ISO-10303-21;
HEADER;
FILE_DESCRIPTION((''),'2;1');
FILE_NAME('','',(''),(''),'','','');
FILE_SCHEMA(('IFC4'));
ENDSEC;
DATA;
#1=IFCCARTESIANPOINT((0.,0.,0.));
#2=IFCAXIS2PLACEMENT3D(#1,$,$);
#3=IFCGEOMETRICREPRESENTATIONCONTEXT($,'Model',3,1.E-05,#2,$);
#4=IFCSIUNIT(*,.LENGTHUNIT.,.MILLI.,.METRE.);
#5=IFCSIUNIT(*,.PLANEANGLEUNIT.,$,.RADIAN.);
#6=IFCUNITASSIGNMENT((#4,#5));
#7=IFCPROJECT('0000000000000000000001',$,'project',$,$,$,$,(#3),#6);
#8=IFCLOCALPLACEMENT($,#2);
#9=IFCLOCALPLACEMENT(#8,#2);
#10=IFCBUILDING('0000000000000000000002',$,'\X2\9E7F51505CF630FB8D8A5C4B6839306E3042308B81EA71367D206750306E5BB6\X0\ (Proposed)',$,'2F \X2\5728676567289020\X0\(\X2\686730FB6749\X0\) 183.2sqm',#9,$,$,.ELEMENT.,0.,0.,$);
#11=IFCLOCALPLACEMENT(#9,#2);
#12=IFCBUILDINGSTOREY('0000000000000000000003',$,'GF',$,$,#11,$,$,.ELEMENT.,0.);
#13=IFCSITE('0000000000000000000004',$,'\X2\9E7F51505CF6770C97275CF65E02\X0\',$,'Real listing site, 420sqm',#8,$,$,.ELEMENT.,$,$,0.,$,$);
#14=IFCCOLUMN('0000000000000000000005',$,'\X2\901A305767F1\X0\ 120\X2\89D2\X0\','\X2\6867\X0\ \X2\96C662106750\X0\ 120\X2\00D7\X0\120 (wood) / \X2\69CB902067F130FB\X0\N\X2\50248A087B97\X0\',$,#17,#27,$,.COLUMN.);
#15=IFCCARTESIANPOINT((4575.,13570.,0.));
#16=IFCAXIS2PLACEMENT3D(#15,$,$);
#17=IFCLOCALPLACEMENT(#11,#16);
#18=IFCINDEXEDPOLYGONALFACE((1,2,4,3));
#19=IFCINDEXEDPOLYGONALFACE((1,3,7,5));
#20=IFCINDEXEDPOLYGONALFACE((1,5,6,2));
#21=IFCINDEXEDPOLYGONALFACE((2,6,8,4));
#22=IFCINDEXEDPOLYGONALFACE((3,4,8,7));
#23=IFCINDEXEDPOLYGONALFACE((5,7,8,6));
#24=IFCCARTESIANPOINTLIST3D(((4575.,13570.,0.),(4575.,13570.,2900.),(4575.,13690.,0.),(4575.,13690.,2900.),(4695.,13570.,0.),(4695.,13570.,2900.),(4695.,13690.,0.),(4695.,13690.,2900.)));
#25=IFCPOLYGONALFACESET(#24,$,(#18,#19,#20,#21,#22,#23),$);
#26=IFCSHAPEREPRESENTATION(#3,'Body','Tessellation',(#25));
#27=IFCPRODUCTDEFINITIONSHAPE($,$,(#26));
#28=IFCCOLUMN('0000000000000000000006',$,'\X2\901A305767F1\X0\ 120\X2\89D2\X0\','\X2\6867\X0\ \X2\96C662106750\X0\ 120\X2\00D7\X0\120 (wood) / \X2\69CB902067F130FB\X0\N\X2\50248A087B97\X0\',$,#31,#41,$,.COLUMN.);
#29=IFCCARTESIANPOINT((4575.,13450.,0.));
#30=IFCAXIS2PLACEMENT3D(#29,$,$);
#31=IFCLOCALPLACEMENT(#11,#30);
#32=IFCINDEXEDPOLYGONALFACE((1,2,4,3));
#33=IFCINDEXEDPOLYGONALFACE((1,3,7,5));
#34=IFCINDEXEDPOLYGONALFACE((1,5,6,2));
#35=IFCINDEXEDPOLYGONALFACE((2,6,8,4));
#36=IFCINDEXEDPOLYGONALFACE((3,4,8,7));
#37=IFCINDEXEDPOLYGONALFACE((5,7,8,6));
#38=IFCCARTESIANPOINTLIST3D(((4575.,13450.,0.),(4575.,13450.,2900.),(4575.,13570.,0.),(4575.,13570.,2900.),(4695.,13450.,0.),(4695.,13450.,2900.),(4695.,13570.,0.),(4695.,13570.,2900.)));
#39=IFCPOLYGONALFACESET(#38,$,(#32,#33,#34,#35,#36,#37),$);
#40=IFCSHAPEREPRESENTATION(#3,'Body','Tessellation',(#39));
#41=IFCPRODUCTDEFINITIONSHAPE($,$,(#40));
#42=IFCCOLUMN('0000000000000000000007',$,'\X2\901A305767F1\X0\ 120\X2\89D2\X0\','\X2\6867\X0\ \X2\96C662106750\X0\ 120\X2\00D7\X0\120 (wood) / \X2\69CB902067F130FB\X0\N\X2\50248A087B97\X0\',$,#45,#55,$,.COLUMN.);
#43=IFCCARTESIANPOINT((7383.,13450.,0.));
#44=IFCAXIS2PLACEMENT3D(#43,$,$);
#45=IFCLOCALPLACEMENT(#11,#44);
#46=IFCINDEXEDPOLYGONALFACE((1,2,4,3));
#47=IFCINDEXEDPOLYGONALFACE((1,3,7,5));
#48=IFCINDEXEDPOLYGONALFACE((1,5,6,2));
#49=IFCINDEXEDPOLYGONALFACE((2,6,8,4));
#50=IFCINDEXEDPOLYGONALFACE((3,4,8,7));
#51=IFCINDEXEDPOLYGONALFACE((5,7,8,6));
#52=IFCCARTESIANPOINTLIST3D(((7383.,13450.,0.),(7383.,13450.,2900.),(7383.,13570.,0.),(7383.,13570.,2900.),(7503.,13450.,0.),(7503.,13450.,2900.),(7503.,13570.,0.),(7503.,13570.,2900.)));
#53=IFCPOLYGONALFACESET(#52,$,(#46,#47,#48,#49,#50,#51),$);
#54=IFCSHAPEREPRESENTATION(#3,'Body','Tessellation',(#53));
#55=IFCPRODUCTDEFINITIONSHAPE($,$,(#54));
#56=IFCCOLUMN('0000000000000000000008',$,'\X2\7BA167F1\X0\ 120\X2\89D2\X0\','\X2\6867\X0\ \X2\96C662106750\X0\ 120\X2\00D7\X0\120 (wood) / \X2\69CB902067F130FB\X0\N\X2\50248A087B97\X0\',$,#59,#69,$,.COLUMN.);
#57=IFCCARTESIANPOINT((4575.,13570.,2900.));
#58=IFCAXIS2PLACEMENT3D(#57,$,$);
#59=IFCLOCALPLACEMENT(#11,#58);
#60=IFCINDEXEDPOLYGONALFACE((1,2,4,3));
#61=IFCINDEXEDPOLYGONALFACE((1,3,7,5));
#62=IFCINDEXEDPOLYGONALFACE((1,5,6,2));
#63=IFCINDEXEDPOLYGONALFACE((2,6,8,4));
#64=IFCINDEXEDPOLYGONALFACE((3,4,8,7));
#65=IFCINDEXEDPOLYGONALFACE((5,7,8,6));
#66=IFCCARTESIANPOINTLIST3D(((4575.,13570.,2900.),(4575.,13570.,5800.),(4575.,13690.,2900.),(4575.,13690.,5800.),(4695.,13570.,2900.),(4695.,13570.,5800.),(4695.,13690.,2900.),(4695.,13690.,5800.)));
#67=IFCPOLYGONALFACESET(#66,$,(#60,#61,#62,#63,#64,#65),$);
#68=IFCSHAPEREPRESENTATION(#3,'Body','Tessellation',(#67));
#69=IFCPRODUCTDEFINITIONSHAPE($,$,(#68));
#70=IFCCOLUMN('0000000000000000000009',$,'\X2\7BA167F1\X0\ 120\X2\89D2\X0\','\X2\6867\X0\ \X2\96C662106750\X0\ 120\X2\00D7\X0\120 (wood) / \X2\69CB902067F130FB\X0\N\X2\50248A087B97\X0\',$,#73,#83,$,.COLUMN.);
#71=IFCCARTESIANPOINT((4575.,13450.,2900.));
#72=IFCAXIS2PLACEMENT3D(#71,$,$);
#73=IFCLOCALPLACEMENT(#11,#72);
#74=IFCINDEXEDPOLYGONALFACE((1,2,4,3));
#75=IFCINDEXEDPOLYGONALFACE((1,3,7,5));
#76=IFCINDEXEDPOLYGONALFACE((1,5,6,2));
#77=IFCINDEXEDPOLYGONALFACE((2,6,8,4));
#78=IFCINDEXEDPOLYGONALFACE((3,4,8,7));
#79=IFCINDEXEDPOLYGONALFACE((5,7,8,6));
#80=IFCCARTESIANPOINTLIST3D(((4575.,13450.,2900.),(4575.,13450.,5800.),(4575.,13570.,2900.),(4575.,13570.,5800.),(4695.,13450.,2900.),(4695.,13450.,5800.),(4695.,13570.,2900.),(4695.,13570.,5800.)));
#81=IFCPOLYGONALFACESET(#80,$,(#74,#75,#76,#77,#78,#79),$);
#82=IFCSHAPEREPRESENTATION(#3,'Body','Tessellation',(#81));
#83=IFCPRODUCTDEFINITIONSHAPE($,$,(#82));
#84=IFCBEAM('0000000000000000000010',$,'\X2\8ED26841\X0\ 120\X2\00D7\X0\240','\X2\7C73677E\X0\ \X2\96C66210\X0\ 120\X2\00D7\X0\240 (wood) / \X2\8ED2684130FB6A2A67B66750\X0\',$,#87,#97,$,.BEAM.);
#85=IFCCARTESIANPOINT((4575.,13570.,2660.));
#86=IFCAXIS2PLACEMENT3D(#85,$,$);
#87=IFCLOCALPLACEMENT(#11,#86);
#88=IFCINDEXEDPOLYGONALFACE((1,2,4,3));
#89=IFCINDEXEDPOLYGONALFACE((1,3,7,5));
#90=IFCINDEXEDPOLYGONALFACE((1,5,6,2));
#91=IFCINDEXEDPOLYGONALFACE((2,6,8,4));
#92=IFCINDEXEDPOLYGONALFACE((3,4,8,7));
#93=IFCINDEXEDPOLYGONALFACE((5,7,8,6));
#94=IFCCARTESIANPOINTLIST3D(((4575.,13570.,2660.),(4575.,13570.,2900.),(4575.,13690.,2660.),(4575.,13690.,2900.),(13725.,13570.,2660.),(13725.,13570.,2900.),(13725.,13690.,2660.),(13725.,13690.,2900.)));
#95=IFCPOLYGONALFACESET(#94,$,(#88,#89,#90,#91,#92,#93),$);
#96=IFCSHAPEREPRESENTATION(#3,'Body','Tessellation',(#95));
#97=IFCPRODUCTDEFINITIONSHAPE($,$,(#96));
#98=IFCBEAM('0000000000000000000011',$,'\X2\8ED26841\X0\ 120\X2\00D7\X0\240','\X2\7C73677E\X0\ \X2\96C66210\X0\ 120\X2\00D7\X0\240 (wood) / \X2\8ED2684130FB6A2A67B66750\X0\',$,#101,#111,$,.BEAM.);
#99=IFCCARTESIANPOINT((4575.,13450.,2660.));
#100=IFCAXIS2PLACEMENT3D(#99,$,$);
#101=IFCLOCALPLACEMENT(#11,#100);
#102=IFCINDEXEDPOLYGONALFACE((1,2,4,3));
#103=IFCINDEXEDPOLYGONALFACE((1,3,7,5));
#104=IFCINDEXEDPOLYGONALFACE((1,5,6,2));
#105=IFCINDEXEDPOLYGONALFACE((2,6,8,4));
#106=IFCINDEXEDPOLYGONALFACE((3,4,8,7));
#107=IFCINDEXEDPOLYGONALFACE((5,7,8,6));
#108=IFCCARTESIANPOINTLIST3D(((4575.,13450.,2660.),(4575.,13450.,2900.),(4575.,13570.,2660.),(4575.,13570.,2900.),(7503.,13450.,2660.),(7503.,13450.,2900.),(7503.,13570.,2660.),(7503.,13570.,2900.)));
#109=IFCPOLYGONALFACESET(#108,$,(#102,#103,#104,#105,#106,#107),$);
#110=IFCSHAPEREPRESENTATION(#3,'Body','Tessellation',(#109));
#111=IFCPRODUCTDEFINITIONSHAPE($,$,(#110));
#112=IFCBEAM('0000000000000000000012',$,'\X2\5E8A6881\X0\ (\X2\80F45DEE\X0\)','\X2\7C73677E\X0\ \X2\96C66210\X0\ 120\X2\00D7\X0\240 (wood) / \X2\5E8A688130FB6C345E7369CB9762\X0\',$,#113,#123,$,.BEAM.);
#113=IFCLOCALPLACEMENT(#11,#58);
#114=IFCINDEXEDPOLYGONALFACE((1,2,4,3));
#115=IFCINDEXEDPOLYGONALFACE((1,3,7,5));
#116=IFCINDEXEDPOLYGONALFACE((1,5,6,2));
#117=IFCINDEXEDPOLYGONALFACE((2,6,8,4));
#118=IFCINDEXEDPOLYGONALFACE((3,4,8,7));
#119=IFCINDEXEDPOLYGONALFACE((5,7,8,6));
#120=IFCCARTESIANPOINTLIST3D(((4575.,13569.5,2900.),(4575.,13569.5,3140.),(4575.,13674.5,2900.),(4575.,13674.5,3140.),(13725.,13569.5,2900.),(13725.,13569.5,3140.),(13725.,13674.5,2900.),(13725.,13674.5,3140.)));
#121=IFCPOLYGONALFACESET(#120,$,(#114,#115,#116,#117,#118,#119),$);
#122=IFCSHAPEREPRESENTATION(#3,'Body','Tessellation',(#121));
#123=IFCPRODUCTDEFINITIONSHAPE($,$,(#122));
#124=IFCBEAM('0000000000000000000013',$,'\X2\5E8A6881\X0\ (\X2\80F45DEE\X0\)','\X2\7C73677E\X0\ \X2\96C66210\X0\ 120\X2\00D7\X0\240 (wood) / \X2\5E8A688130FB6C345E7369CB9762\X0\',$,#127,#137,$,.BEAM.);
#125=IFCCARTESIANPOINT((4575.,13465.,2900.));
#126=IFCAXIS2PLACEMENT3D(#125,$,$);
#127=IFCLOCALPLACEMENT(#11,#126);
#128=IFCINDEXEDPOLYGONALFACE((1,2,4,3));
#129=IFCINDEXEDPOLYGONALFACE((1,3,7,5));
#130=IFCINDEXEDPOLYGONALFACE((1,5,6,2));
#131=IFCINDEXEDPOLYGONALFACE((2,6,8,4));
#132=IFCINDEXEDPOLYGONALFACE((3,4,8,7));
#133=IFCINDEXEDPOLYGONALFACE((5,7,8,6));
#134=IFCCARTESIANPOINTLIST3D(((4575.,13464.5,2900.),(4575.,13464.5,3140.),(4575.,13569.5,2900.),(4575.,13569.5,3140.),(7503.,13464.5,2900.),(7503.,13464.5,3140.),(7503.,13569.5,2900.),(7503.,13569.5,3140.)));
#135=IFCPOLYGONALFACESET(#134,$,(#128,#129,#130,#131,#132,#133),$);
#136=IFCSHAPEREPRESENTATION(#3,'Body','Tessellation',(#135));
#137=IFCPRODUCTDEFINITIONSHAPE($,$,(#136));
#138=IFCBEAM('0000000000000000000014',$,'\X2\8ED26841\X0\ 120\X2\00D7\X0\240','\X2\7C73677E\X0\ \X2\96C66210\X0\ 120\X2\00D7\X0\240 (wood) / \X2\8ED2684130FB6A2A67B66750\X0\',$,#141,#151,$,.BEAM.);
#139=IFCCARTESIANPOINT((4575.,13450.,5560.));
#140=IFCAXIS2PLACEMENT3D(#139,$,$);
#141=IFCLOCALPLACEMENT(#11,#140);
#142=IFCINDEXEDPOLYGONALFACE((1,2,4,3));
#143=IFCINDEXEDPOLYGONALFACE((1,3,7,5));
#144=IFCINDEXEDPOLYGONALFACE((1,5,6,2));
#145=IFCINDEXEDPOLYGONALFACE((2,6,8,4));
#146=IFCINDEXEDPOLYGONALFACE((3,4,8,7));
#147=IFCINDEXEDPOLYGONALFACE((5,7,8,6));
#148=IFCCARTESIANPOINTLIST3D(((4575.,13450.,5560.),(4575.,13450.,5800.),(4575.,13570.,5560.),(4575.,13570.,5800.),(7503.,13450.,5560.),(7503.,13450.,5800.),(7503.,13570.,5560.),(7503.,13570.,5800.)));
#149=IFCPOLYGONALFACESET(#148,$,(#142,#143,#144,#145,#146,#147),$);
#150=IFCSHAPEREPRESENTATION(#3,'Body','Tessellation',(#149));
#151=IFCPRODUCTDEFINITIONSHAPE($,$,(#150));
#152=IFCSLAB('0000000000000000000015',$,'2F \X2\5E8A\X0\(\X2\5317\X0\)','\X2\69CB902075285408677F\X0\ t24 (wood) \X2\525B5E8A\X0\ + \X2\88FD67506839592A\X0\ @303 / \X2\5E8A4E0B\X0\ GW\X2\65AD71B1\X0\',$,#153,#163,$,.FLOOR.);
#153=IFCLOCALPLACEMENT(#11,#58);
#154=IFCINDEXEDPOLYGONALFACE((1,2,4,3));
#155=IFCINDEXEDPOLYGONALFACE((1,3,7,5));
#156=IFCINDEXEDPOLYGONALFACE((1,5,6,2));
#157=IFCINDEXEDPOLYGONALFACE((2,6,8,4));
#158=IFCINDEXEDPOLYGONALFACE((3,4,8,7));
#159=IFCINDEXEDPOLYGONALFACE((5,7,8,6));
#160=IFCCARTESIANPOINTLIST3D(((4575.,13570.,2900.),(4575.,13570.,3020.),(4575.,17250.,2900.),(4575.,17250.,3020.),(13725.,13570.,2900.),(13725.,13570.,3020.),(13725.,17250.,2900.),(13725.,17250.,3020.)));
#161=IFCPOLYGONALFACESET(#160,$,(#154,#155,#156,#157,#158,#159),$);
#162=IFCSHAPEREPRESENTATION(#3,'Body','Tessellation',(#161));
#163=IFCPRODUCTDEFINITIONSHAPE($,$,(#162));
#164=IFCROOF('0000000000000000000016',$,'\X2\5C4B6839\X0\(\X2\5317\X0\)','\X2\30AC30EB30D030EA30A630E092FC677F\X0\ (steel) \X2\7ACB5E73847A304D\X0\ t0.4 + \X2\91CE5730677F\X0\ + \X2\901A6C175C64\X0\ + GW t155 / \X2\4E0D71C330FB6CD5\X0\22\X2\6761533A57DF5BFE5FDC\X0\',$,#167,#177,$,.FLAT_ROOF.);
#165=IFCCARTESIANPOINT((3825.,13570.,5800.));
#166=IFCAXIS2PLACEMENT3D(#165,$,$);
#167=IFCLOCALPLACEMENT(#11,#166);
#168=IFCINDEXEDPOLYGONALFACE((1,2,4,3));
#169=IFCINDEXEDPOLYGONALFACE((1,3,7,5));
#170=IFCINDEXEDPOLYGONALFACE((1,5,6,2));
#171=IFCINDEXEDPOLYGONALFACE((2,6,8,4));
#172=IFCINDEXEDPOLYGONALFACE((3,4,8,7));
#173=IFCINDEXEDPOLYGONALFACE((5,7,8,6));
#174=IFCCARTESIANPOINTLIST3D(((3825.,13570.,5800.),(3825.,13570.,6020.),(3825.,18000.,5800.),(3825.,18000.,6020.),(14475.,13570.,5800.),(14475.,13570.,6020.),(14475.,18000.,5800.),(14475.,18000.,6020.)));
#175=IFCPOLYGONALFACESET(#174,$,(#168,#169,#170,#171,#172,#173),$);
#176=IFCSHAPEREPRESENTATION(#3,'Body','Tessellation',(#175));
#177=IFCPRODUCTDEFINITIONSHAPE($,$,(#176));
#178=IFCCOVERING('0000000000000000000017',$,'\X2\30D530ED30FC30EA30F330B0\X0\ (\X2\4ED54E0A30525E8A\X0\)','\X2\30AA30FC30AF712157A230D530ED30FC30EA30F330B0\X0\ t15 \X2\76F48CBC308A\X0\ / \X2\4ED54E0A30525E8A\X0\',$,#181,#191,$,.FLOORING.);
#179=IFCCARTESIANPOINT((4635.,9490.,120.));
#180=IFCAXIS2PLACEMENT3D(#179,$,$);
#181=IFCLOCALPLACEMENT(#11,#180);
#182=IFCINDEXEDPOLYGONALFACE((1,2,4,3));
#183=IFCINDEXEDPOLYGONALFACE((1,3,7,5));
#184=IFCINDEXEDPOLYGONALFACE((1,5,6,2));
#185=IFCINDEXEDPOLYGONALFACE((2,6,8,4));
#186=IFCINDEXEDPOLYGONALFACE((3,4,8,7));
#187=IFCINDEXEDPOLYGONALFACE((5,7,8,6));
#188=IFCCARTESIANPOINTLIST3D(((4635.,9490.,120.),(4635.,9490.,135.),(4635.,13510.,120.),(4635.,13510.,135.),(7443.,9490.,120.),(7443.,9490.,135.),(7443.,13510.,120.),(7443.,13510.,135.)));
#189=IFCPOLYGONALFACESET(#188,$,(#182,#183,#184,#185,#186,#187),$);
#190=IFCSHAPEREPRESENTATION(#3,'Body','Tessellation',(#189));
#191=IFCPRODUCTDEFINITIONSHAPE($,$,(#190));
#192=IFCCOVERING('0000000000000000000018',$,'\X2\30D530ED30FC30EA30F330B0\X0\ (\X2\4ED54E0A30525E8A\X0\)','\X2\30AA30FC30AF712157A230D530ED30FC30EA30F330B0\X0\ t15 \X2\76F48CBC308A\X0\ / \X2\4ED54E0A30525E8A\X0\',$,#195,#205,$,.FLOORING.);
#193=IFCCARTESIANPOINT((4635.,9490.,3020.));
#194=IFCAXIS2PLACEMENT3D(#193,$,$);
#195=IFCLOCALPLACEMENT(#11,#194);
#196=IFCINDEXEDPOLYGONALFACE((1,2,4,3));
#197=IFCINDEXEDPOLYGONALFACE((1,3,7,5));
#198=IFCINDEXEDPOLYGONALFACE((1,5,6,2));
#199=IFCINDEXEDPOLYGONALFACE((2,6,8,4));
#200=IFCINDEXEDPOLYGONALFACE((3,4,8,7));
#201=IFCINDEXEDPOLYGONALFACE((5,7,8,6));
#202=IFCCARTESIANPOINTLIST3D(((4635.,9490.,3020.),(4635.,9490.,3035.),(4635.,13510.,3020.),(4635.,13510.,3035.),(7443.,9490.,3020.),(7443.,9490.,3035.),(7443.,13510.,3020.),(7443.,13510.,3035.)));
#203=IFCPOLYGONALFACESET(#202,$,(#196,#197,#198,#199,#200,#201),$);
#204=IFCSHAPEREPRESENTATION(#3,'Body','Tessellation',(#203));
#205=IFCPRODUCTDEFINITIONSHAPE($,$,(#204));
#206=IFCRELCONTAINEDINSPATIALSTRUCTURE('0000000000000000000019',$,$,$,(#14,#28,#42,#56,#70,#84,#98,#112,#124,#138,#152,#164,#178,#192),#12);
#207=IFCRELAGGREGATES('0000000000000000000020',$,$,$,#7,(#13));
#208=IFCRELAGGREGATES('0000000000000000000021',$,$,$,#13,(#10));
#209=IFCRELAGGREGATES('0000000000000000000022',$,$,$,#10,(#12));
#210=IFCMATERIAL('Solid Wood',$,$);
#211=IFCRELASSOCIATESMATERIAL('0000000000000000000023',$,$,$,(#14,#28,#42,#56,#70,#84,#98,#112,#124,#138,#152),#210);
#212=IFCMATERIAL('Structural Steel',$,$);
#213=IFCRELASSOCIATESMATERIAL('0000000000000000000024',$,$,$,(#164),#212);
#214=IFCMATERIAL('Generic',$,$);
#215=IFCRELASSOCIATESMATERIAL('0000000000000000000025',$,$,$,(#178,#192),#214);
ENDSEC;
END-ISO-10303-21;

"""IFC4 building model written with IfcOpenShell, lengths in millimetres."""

from ifc_helpers import new_model, si_unit, frame, frame_2d, origin, place, context, project, spatial, rectangle, extrude, material, element, save


model = new_model("IFC4")

# Units and contexts
model_context = context("Model", 3, precision=1e-05, world=origin())
ifc_project = project(units=[si_unit("LENGTHUNIT", "METRE", prefix="MILLI"), si_unit("PLANEANGLEUNIT", "RADIAN")], contexts=[model_context])

# Site, building, storey
site_placement = place(None, origin())
site = spatial("IfcSite", under=ifc_project, at=site_placement, Name="鹿児島県霧島市", ObjectType="Real listing site, 420sqm", CompositionType="ELEMENT", RefElevation=0.0)
building_placement = place(site_placement, origin())
building = spatial("IfcBuilding", under=site, at=building_placement, Name="鹿児島・越屋根のある自然素材の家 (Proposed)", ObjectType="2F 在来木造(桧・杉) 183.2sqm", CompositionType="ELEMENT", ElevationOfRefHeight=0.0, ElevationOfTerrain=0.0)
storey_placement = place(building_placement, origin())
storey = spatial("IfcBuildingStorey", under=building, at=storey_placement, Name="GF", CompositionType="ELEMENT", Elevation=0.0)

# Columns
ifc_material_1 = material(Name="Solid Wood")
column_1_placement = place(storey_placement, frame((4575.0, 13570.0, 0.0)))
element("IfcColumn", 1, at=column_1_placement, inside=storey, material=ifc_material_1, Name="通し柱 120角", Description="桧 集成材 120×120 (wood) / 構造柱・N値計算", PredefinedType="COLUMN", context=model_context, shape_type="SweptSolid", body=[
    extrude(rectangle(XDim=120.0, YDim=120.0, at=frame_2d((60.0, 60.0))), frame((4575.0, 13570.0, 0.0)), (0.0, 0.0, 1.0), 2900.0),
])
column_2_placement = place(storey_placement, frame((4575.0, 13450.0, 0.0)))
element("IfcColumn", 2, at=column_2_placement, inside=storey, material=ifc_material_1, Name="通し柱 120角", Description="桧 集成材 120×120 (wood) / 構造柱・N値計算", PredefinedType="COLUMN", context=model_context, shape_type="SweptSolid", body=[
    extrude(rectangle(XDim=120.0, YDim=120.0, at=frame_2d((60.0, 60.0))), frame((4575.0, 13450.0, 0.0)), (0.0, 0.0, 1.0), 2900.0),
])
column_3_placement = place(storey_placement, frame((7383.0, 13450.0, 0.0)))
element("IfcColumn", 3, at=column_3_placement, inside=storey, material=ifc_material_1, Name="通し柱 120角", Description="桧 集成材 120×120 (wood) / 構造柱・N値計算", PredefinedType="COLUMN", context=model_context, shape_type="SweptSolid", body=[
    extrude(rectangle(XDim=120.0, YDim=120.0, at=frame_2d((60.0, 60.0))), frame((7383.0, 13450.0, 0.0)), (0.0, 0.0, 1.0), 2900.0),
])
column_4_placement = place(storey_placement, frame((4575.0, 13570.0, 2900.0)))
element("IfcColumn", 4, at=column_4_placement, inside=storey, material=ifc_material_1, Name="管柱 120角", Description="桧 集成材 120×120 (wood) / 構造柱・N値計算", PredefinedType="COLUMN", context=model_context, shape_type="SweptSolid", body=[
    extrude(rectangle(XDim=120.0, YDim=120.0, at=frame_2d((60.0, 60.0))), frame((4575.0, 13570.0, 2900.0)), (0.0, 0.0, 1.0), 2900.0),
])
column_5_placement = place(storey_placement, frame((4575.0, 13450.0, 2900.0)))
element("IfcColumn", 5, at=column_5_placement, inside=storey, material=ifc_material_1, Name="管柱 120角", Description="桧 集成材 120×120 (wood) / 構造柱・N値計算", PredefinedType="COLUMN", context=model_context, shape_type="SweptSolid", body=[
    extrude(rectangle(XDim=120.0, YDim=120.0, at=frame_2d((60.0, 60.0))), frame((4575.0, 13450.0, 2900.0)), (0.0, 0.0, 1.0), 2900.0),
])

# Beams
beam_1_placement = place(storey_placement, frame((4575.0, 13570.0, 2660.0)))
element("IfcBeam", 6, at=beam_1_placement, inside=storey, material=ifc_material_1, Name="軒桁 120×240", Description="米松 集成 120×240 (wood) / 軒桁・横架材", PredefinedType="BEAM", context=model_context, shape_type="SweptSolid", body=[
    extrude(rectangle(XDim=9150.0, YDim=120.0, at=frame_2d((4575.0, 60.0))), frame((4575.0, 13570.0, 2660.0)), (0.0, 0.0, 1.0), 240.0),
])
beam_2_placement = place(storey_placement, frame((4575.0, 13450.0, 2660.0)))
element("IfcBeam", 7, at=beam_2_placement, inside=storey, material=ifc_material_1, Name="軒桁 120×240", Description="米松 集成 120×240 (wood) / 軒桁・横架材", PredefinedType="BEAM", context=model_context, shape_type="SweptSolid", body=[
    extrude(rectangle(XDim=2928.0, YDim=120.0, at=frame_2d((1464.0, 60.0))), frame((4575.0, 13450.0, 2660.0)), (0.0, 0.0, 1.0), 240.0),
])
beam_3_placement = place(storey_placement, frame((4575.0, 13570.0, 2900.0)))
element("IfcBeam", 8, at=beam_3_placement, inside=storey, material=ifc_material_1, Name="床梁 (胴差)", Description="米松 集成 120×240 (wood) / 床梁・水平構面", PredefinedType="BEAM", context=model_context, shape_type="SweptSolid", body=[
    extrude(rectangle(XDim=9150.0, YDim=105.0, at=frame_2d((4575.0, 52.0))), frame((4575.0, 13570.0, 2900.0)), (0.0, 0.0, 1.0), 240.0),
])
beam_4_placement = place(storey_placement, frame((4575.0, 13465.0, 2900.0)))
element("IfcBeam", 9, at=beam_4_placement, inside=storey, material=ifc_material_1, Name="床梁 (胴差)", Description="米松 集成 120×240 (wood) / 床梁・水平構面", PredefinedType="BEAM", context=model_context, shape_type="SweptSolid", body=[
    extrude(rectangle(XDim=2928.0, YDim=105.0, at=frame_2d((1464.0, 52.0))), frame((4575.0, 13465.0, 2900.0)), (0.0, 0.0, 1.0), 240.0),
])
beam_5_placement = place(storey_placement, frame((4575.0, 13450.0, 5560.0)))
element("IfcBeam", 10, at=beam_5_placement, inside=storey, material=ifc_material_1, Name="軒桁 120×240", Description="米松 集成 120×240 (wood) / 軒桁・横架材", PredefinedType="BEAM", context=model_context, shape_type="SweptSolid", body=[
    extrude(rectangle(XDim=2928.0, YDim=120.0, at=frame_2d((1464.0, 60.0))), frame((4575.0, 13450.0, 5560.0)), (0.0, 0.0, 1.0), 240.0),
])

# Slab
slab_1_placement = place(storey_placement, frame((4575.0, 13570.0, 2900.0)))
element("IfcSlab", 11, at=slab_1_placement, inside=storey, material=ifc_material_1, Name="2F 床(北)", Description="構造用合板 t24 (wood) 剛床 + 製材根太 @303 / 床下 GW断熱", PredefinedType="FLOOR", context=model_context, shape_type="SweptSolid", body=[
    extrude(rectangle(XDim=9150.0, YDim=3680.0, at=frame_2d((4575.0, 1840.0))), frame((4575.0, 13570.0, 2900.0)), (0.0, 0.0, 1.0), 120.0),
])

# Roof
ifc_material_2 = material(Name="Structural Steel")
for number, where, name in (
    (12, (3825.0, 13570.0, 5800.0), "屋根(北)"),
):
    element("IfcRoof", number, at=place(storey_placement, frame(where)), inside=storey, material=ifc_material_2, Name=name, Description="ガルバリウム鋼板 (steel) 立平葺き t0.4 + 野地板 + 通気層 + GW t155 / 不燃・法22条区域対応", PredefinedType="FLAT_ROOF", context=model_context, shape_type="SweptSolid", body=[
        extrude(rectangle(XDim=10650.0, YDim=4430.0, at=frame_2d((5325.0, 2215.0))), frame((3825.0, 13570.0, 5800.0)), (0.0, 0.0, 1.0), 220.0),
    ])

# Coverings
ifc_material_3 = material(Name="Generic")
covering_1_placement = place(storey_placement, frame((4635.0, 9490.0, 120.0)))
element("IfcCovering", 13, at=covering_1_placement, inside=storey, material=ifc_material_3, Name="フローリング (仕上げ床)", Description="オーク無垢フローリング t15 直貼り / 仕上げ床", PredefinedType="FLOORING", context=model_context, shape_type="SweptSolid", body=[
    extrude(rectangle(XDim=2808.0, YDim=4020.0, at=frame_2d((1404.0, 2010.0))), frame((4635.0, 9490.0, 120.0)), (0.0, 0.0, 1.0), 15.0),
])
covering_2_placement = place(storey_placement, frame((4635.0, 9490.0, 3020.0)))
element("IfcCovering", 14, at=covering_2_placement, inside=storey, material=ifc_material_3, Name="フローリング (仕上げ床)", Description="オーク無垢フローリング t15 直貼り / 仕上げ床", PredefinedType="FLOORING", context=model_context, shape_type="SweptSolid", body=[
    extrude(rectangle(XDim=2808.0, YDim=4020.0, at=frame_2d((1404.0, 2010.0))), frame((4635.0, 9490.0, 3020.0)), (0.0, 0.0, 1.0), 15.0),
])

save(model, "model.ifc")
